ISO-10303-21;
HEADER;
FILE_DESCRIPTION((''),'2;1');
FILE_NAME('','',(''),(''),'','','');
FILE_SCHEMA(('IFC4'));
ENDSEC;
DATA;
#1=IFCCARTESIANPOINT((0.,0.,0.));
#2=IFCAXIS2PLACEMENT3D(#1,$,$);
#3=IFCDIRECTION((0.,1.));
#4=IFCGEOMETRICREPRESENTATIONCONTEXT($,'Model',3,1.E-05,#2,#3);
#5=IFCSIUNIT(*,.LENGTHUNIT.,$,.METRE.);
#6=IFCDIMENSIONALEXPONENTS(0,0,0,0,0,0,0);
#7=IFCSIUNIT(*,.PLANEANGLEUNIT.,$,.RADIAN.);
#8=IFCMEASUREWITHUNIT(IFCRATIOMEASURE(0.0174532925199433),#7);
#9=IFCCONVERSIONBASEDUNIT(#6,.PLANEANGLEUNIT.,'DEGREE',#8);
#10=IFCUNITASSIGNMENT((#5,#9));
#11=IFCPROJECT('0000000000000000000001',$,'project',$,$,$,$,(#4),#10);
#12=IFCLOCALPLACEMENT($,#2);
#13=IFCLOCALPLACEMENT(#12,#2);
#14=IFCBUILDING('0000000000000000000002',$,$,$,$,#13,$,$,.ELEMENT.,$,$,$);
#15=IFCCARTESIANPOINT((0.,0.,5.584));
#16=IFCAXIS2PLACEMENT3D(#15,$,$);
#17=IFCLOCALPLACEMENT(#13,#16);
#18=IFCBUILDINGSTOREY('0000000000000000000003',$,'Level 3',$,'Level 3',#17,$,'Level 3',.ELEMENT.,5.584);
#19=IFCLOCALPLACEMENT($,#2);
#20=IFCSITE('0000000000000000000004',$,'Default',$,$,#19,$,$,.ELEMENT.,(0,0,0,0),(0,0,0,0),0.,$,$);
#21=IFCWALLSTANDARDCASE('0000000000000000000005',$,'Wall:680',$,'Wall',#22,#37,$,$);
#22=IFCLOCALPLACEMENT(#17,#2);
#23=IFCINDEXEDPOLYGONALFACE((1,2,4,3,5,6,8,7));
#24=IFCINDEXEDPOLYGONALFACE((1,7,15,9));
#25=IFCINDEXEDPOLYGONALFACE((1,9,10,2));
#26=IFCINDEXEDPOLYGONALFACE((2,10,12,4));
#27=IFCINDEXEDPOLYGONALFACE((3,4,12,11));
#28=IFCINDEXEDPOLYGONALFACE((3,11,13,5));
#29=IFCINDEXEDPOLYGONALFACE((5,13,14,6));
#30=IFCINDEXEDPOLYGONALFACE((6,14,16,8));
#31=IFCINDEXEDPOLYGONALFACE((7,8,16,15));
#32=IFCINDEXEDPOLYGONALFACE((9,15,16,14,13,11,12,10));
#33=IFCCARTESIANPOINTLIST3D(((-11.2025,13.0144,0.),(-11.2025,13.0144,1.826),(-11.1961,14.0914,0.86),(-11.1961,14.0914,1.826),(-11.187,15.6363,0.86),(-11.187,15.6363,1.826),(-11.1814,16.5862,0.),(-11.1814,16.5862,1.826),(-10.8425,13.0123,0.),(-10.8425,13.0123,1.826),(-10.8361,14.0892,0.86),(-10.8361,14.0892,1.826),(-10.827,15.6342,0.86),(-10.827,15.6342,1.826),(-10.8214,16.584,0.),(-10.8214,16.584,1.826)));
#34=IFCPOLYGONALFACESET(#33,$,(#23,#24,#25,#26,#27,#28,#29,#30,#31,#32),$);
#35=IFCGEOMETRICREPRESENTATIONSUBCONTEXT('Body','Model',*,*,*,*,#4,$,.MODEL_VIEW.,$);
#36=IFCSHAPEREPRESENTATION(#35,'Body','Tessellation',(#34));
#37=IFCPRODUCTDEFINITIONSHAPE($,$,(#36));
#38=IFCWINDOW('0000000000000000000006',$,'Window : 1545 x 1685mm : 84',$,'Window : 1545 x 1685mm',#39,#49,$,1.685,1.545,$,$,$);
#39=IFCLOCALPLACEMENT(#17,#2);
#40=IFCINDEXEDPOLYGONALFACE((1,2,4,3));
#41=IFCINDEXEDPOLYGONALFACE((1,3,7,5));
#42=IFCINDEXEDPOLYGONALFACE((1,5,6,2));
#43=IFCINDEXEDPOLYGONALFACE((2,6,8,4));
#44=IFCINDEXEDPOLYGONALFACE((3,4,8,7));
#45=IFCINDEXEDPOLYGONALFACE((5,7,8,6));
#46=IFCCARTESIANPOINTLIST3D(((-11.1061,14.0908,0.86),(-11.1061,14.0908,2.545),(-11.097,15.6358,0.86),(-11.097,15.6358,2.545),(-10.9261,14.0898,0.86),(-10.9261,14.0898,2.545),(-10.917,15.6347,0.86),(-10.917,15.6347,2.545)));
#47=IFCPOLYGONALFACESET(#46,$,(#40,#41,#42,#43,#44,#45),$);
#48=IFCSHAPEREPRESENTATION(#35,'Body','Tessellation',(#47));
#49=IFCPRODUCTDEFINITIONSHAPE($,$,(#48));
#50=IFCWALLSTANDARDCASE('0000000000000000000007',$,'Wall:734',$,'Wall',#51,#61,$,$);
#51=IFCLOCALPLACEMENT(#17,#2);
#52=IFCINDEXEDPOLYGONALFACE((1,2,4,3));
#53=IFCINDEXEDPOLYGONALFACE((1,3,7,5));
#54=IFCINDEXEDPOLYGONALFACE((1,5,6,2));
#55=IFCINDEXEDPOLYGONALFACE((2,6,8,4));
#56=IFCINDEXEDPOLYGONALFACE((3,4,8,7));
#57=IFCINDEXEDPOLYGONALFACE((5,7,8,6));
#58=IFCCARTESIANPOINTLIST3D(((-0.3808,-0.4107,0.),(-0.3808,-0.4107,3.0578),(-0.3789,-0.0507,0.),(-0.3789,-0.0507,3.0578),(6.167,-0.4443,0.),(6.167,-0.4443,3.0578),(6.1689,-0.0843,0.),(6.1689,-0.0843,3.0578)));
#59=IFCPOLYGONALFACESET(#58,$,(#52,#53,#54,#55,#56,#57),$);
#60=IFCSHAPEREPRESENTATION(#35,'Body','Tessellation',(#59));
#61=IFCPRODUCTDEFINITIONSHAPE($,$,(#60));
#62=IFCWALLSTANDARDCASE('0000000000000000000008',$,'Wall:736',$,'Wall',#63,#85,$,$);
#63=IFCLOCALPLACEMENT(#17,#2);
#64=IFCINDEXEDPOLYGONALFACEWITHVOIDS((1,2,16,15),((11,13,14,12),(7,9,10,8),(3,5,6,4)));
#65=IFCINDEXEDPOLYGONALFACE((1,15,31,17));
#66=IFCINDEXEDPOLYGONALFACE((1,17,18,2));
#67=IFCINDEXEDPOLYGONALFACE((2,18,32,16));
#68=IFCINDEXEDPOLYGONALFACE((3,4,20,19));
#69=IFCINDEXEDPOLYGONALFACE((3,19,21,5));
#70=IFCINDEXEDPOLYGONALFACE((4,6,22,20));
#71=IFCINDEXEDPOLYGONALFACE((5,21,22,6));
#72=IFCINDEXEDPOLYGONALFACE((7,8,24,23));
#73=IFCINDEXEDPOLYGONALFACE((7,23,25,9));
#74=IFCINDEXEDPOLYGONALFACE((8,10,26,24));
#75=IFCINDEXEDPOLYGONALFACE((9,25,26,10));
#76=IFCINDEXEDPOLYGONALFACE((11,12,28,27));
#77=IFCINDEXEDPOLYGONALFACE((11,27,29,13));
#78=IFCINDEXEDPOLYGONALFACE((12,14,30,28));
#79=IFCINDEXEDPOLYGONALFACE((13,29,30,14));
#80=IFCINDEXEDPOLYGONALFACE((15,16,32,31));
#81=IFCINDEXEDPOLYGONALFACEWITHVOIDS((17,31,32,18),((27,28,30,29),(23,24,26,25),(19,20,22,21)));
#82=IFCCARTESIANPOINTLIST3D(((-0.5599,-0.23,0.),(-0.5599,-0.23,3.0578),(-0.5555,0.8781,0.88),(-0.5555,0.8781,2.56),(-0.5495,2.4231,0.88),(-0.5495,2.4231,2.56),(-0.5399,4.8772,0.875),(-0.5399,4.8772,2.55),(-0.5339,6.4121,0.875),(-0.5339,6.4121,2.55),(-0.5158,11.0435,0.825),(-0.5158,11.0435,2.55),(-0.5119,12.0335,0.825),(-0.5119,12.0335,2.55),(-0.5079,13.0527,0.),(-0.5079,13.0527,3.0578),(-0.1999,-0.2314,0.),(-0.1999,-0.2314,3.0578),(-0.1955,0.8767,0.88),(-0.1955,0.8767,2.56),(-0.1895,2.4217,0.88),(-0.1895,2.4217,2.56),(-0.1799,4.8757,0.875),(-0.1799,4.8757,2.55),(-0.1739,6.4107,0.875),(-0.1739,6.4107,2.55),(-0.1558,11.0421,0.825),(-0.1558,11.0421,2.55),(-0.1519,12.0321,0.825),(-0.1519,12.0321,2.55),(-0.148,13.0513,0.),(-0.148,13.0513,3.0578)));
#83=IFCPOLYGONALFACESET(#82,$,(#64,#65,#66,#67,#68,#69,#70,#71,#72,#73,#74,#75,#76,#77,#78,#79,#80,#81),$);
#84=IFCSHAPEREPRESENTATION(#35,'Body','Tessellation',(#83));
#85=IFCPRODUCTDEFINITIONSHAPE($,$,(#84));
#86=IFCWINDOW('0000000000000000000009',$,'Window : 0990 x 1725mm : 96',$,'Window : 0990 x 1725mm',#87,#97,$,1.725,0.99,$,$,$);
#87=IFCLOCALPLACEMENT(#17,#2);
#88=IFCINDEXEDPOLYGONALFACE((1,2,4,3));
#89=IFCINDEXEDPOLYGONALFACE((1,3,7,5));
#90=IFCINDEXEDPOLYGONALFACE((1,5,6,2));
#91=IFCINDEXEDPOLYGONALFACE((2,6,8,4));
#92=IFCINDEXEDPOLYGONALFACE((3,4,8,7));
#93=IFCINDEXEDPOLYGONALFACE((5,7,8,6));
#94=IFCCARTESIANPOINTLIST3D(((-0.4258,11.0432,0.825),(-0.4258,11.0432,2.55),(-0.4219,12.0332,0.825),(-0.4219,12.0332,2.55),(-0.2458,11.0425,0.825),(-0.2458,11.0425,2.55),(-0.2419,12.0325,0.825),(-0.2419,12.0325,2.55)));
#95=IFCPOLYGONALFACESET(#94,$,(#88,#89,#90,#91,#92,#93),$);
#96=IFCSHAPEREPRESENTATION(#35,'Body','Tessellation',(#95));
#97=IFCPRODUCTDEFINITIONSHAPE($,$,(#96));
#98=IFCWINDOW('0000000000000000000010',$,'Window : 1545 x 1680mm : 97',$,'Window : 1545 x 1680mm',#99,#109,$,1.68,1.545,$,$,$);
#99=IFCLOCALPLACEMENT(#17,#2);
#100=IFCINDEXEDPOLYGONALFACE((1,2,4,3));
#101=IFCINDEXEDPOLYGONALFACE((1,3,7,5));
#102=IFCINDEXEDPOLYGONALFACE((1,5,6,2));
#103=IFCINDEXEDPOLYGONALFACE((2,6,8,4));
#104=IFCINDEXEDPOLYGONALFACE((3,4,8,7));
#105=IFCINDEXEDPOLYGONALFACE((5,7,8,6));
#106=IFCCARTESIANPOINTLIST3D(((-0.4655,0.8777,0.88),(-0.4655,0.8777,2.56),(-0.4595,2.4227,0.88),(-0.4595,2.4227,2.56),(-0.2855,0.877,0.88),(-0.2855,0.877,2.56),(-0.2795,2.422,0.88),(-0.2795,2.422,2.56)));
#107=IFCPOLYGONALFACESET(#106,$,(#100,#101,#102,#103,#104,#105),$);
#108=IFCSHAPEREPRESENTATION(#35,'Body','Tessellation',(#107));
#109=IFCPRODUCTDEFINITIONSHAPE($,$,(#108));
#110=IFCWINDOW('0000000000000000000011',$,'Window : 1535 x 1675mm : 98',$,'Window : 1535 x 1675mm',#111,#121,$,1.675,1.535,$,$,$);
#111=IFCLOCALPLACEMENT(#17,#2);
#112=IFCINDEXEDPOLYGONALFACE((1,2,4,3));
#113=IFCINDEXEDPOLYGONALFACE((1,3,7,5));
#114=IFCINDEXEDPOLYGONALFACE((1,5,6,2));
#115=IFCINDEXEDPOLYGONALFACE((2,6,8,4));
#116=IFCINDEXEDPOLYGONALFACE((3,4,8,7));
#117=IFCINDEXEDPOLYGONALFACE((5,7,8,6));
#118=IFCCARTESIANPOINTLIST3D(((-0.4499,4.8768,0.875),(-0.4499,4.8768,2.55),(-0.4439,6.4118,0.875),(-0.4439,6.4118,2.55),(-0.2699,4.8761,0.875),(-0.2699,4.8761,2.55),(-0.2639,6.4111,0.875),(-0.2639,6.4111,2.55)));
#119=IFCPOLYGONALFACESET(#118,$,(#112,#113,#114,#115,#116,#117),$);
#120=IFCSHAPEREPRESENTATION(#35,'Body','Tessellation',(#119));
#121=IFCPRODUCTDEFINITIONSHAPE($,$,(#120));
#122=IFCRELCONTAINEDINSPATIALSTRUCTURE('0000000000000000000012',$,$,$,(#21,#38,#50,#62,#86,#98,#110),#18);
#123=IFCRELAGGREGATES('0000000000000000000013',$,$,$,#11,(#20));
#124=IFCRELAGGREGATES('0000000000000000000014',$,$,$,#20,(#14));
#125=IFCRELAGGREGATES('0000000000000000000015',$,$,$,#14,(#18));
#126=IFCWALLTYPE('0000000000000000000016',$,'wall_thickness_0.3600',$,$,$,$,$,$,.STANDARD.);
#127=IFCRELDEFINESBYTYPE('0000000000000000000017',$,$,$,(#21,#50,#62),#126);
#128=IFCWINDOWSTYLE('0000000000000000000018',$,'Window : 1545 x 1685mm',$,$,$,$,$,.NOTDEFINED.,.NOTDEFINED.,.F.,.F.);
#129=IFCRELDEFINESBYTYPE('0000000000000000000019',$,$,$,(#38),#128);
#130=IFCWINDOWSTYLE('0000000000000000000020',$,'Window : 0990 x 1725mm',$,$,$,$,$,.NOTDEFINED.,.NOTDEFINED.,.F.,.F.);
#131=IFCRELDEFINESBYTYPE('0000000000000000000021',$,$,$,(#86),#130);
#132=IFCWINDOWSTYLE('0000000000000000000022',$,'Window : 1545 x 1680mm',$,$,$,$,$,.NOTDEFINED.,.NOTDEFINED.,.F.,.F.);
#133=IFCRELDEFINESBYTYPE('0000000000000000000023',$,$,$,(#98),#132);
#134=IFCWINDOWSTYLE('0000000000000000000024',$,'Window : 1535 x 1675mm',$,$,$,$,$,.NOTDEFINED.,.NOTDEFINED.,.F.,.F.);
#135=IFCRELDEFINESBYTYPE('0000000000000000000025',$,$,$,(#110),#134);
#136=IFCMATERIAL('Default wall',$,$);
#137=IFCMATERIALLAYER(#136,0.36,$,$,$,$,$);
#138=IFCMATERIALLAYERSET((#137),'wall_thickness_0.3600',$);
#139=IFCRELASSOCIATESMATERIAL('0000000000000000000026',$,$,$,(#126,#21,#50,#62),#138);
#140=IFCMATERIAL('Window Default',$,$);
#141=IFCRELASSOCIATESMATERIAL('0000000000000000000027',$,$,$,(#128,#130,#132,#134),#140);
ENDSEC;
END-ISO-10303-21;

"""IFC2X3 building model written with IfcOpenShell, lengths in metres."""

from ifc_helpers import new_model, entity, si_unit, converted_unit, direction, frame, frame_2d, origin, origin_2d_with_axis, place, context, subcontext, project, spatial, polyline, rectangle, outline, extrude, source, transform, mapped, material, layer, layer_set, layer_usage, type_object, type_shapes, element, fill, save


model = new_model("IFC2X3")

# Units and contexts
model_context = context("Model", 3, precision=1e-05, world=origin(), true_north=direction((0.0, 1.0)))
body_context = subcontext(model_context, "Body", "Model", "MODEL_VIEW")
ifc_project = project(units=[si_unit("LENGTHUNIT", "METRE"), converted_unit("PLANEANGLEUNIT", "DEGREE", entity("IfcRatioMeasure", 0.0174532925199433), si_unit("PLANEANGLEUNIT", "RADIAN"), dimensions=[0, 0, 0, 0, 0, 0, 0])], contexts=[model_context])

# Site, building, storey
site_placement = place(None, origin())
site = spatial("IfcSite", under=ifc_project, at=site_placement, Name="Default", CompositionType="ELEMENT", RefLatitude=(0, 0, 0, 0), RefLongitude=(0, 0, 0, 0), RefElevation=0.0)
placement_1 = place(None, origin())
building_placement = place(placement_1, origin())
building = spatial("IfcBuilding", under=site, at=building_placement, CompositionType="ELEMENT")
storey_placement = place(building_placement, frame((0.0, 0.0, 5.584)))
storey = spatial("IfcBuildingStorey", under=building, at=storey_placement, Name="Level 3", ObjectType="Level 3", LongName="Level 3", CompositionType="ELEMENT", Elevation=5.584)

# Shared definitions
ifc_material_1 = material(Name="Default wall")
ifc_material_2 = material(Name="Window Default")

# Wall, opening, window
ifc_layer_1 = layer(ifc_material_1, 0.36)
ifc_layer_set_1 = layer_set([ifc_layer_1], Name="wall_thickness_0.3600")
ifc_layer_usage_1 = layer_usage(ifc_layer_set_1, "AXIS2", "POSITIVE", -0.18)
wall_type_1 = type_object("IfcWallType", Name="wall_thickness_0.3600", PredefinedType="STANDARD", material=ifc_layer_set_1)
wall_1_placement = place(storey_placement, frame((-11.0014, 16.5851, 0.0), z_axis=(0.0, 0.0, 1.0), x_axis=(-0.005883, -0.999983, 0.0)))
wall_1 = element("IfcWallStandardCase", 1, at=wall_1_placement, inside=storey, type_object=wall_type_1, material=ifc_layer_usage_1, Name="Wall:680", ObjectType="Wall", context=body_context, shape_type="SweptSolid", body=[
    extrude(outline(polyline([(3.5718, -0.18), (3.5718, 0.18), (0.0, 0.18), (0.0, -0.18), (3.5718, -0.18)])), origin(), (0.0, 0.0, 1.0), 1.826),
])
opening_1_placement = place(wall_1_placement, frame((0.9499, -0.18, 0.86)))
opening_1 = element("IfcOpeningElement", 2, at=opening_1_placement, cuts=wall_1, ObjectType="Opening", context=body_context, shape_type="SweptSolid", body=[
    extrude(rectangle(XDim=1.545, YDim=1.685, at=frame_2d((0.8425, 0.7725), x_axis=(0.0, 1.0))), frame((0.0, 0.0, 0.0), z_axis=(0.0, 1.0, 0.0), x_axis=(0.0, 0.0, 1.0)), (0.0, 0.0, 1.0), 0.36),
])
window_style_1 = type_object("IfcWindowStyle", Name="Window : 1545 x 1685mm", ConstructionType="NOTDEFINED", OperationType="NOTDEFINED", ParameterTakesPrecedence=False, Sizeable=False, material=ifc_material_2)
shared_shape_1 = source(origin(), body_context, "Body", "SweptSolid", [
    extrude(rectangle(XDim=0.18, YDim=1.545, at=origin_2d_with_axis()), frame((0.7725, 0.18, 0.0), z_axis=(0.0, 0.0, 1.0), x_axis=(0.0, 1.0, 0.0)), (0.0, 0.0, 1.0), 1.685),
])
type_shapes(window_style_1, [shared_shape_1])
window_1_placement = place(opening_1_placement, origin())
window_1 = element("IfcWindow", 3, at=window_1_placement, inside=storey, type_object=window_style_1, Name="Window : 1545 x 1685mm : 84", ObjectType="Window : 1545 x 1685mm", OverallHeight=1.685, OverallWidth=1.545, context=body_context, shape_type="MappedRepresentation", body=[
    mapped(shared_shape_1, transform((0.0, 0.0, 0.0), scale=1.0)),
])
fill(opening_1, window_1)

# Wall
wall_2_placement = place(storey_placement, frame((-0.3799, -0.2307, 0.0), z_axis=(0.0, 0.0, 1.0), x_axis=(0.999987, -0.005138, 0.0)))
element("IfcWallStandardCase", 4, at=wall_2_placement, inside=storey, type_object=wall_type_1, material=ifc_layer_usage_1, Name="Wall:734", ObjectType="Wall", context=body_context, shape_type="SweptSolid", body=[
    extrude(outline(polyline([(6.5479, -0.18), (6.5479, 0.18), (0.0, 0.18), (0.0, -0.18), (6.5479, -0.18)])), origin(), (0.0, 0.0, 1.0), 3.0578),
])

# Wall, openings, windows
wall_3_placement = place(storey_placement, frame((-0.3279, 13.052, 0.0), z_axis=(0.0, 0.0, 1.0), x_axis=(-0.003909, -0.999992, 0.0)))
wall_3 = element("IfcWallStandardCase", 5, at=wall_3_placement, inside=storey, type_object=wall_type_1, material=ifc_layer_usage_1, Name="Wall:736", ObjectType="Wall", context=body_context, shape_type="SweptSolid", body=[
    extrude(outline(polyline([(13.2828, -0.18), (13.2828, 0.18), (0.0, 0.18), (0.0, -0.18), (13.2828, -0.18)])), origin(), (0.0, 0.0, 1.0), 3.0578),
])
opening_2_placement = place(wall_3_placement, frame((1.0192, -0.18, 0.825)))
opening_2 = element("IfcOpeningElement", 6, at=opening_2_placement, cuts=wall_3, ObjectType="Opening", context=body_context, shape_type="SweptSolid", body=[
    extrude(rectangle(XDim=0.99, YDim=1.725, at=frame_2d((0.8625, 0.495), x_axis=(0.0, 1.0))), frame((0.0, 0.0, 0.0), z_axis=(0.0, 1.0, 0.0), x_axis=(0.0, 0.0, 1.0)), (0.0, 0.0, 1.0), 0.36),
])
opening_3_placement = place(wall_3_placement, frame((10.6297, -0.18, 0.88)))
opening_3 = element("IfcOpeningElement", 7, at=opening_3_placement, cuts=wall_3, ObjectType="Opening", context=body_context, shape_type="SweptSolid", body=[
    extrude(rectangle(XDim=1.545, YDim=1.68, at=frame_2d((0.84, 0.7725), x_axis=(0.0, 1.0))), frame((0.0, 0.0, 0.0), z_axis=(0.0, 1.0, 0.0), x_axis=(0.0, 0.0, 1.0)), (0.0, 0.0, 1.0), 0.36),
])
opening_4_placement = place(wall_3_placement, frame((6.6407, -0.18, 0.875)))
opening_4 = element("IfcOpeningElement", 8, at=opening_4_placement, cuts=wall_3, ObjectType="Opening", context=body_context, shape_type="SweptSolid", body=[
    extrude(rectangle(XDim=1.535, YDim=1.675, at=frame_2d((0.8375, 0.7675), x_axis=(0.0, 1.0))), frame((0.0, 0.0, 0.0), z_axis=(0.0, 1.0, 0.0), x_axis=(0.0, 0.0, 1.0)), (0.0, 0.0, 1.0), 0.36),
])
window_style_2 = type_object("IfcWindowStyle", Name="Window : 0990 x 1725mm", ConstructionType="NOTDEFINED", OperationType="NOTDEFINED", ParameterTakesPrecedence=False, Sizeable=False, material=ifc_material_2)
shared_shape_2 = source(origin(), body_context, "Body", "SweptSolid", [
    extrude(rectangle(XDim=0.18, YDim=0.99, at=origin_2d_with_axis()), frame((0.495, 0.18, 0.0), z_axis=(0.0, 0.0, 1.0), x_axis=(0.0, 1.0, 0.0)), (0.0, 0.0, 1.0), 1.725),
])
type_shapes(window_style_2, [shared_shape_2])
window_2_placement = place(opening_2_placement, origin())
window_2 = element("IfcWindow", 9, at=window_2_placement, inside=storey, type_object=window_style_2, Name="Window : 0990 x 1725mm : 96", ObjectType="Window : 0990 x 1725mm", OverallHeight=1.725, OverallWidth=0.99, context=body_context, shape_type="MappedRepresentation", body=[
    mapped(shared_shape_2, transform((0.0, 0.0, 0.0), scale=1.0)),
])
fill(opening_2, window_2)
window_style_3 = type_object("IfcWindowStyle", Name="Window : 1545 x 1680mm", ConstructionType="NOTDEFINED", OperationType="NOTDEFINED", ParameterTakesPrecedence=False, Sizeable=False, material=ifc_material_2)
shared_shape_3 = source(origin(), body_context, "Body", "SweptSolid", [
    extrude(rectangle(XDim=0.18, YDim=1.545, at=origin_2d_with_axis()), frame((0.7725, 0.18, 0.0), z_axis=(0.0, 0.0, 1.0), x_axis=(0.0, 1.0, 0.0)), (0.0, 0.0, 1.0), 1.68),
])
type_shapes(window_style_3, [shared_shape_3])
window_3_placement = place(opening_3_placement, origin())
window_3 = element("IfcWindow", 10, at=window_3_placement, inside=storey, type_object=window_style_3, Name="Window : 1545 x 1680mm : 97", ObjectType="Window : 1545 x 1680mm", OverallHeight=1.68, OverallWidth=1.545, context=body_context, shape_type="MappedRepresentation", body=[
    mapped(shared_shape_3, transform((0.0, 0.0, 0.0), scale=1.0)),
])
fill(opening_3, window_3)
window_style_4 = type_object("IfcWindowStyle", Name="Window : 1535 x 1675mm", ConstructionType="NOTDEFINED", OperationType="NOTDEFINED", ParameterTakesPrecedence=False, Sizeable=False, material=ifc_material_2)
shared_shape_4 = source(origin(), body_context, "Body", "SweptSolid", [
    extrude(rectangle(XDim=0.18, YDim=1.535, at=origin_2d_with_axis()), frame((0.7675, 0.18, 0.0), z_axis=(0.0, 0.0, 1.0), x_axis=(0.0, 1.0, 0.0)), (0.0, 0.0, 1.0), 1.675),
])
type_shapes(window_style_4, [shared_shape_4])
window_4_placement = place(opening_4_placement, origin())
window_4 = element("IfcWindow", 11, at=window_4_placement, inside=storey, type_object=window_style_4, Name="Window : 1535 x 1675mm : 98", ObjectType="Window : 1535 x 1675mm", OverallHeight=1.675, OverallWidth=1.535, context=body_context, shape_type="MappedRepresentation", body=[
    mapped(shared_shape_4, transform((0.0, 0.0, 0.0), scale=1.0)),
])
fill(opening_4, window_4)

save(model, "model.ifc")
